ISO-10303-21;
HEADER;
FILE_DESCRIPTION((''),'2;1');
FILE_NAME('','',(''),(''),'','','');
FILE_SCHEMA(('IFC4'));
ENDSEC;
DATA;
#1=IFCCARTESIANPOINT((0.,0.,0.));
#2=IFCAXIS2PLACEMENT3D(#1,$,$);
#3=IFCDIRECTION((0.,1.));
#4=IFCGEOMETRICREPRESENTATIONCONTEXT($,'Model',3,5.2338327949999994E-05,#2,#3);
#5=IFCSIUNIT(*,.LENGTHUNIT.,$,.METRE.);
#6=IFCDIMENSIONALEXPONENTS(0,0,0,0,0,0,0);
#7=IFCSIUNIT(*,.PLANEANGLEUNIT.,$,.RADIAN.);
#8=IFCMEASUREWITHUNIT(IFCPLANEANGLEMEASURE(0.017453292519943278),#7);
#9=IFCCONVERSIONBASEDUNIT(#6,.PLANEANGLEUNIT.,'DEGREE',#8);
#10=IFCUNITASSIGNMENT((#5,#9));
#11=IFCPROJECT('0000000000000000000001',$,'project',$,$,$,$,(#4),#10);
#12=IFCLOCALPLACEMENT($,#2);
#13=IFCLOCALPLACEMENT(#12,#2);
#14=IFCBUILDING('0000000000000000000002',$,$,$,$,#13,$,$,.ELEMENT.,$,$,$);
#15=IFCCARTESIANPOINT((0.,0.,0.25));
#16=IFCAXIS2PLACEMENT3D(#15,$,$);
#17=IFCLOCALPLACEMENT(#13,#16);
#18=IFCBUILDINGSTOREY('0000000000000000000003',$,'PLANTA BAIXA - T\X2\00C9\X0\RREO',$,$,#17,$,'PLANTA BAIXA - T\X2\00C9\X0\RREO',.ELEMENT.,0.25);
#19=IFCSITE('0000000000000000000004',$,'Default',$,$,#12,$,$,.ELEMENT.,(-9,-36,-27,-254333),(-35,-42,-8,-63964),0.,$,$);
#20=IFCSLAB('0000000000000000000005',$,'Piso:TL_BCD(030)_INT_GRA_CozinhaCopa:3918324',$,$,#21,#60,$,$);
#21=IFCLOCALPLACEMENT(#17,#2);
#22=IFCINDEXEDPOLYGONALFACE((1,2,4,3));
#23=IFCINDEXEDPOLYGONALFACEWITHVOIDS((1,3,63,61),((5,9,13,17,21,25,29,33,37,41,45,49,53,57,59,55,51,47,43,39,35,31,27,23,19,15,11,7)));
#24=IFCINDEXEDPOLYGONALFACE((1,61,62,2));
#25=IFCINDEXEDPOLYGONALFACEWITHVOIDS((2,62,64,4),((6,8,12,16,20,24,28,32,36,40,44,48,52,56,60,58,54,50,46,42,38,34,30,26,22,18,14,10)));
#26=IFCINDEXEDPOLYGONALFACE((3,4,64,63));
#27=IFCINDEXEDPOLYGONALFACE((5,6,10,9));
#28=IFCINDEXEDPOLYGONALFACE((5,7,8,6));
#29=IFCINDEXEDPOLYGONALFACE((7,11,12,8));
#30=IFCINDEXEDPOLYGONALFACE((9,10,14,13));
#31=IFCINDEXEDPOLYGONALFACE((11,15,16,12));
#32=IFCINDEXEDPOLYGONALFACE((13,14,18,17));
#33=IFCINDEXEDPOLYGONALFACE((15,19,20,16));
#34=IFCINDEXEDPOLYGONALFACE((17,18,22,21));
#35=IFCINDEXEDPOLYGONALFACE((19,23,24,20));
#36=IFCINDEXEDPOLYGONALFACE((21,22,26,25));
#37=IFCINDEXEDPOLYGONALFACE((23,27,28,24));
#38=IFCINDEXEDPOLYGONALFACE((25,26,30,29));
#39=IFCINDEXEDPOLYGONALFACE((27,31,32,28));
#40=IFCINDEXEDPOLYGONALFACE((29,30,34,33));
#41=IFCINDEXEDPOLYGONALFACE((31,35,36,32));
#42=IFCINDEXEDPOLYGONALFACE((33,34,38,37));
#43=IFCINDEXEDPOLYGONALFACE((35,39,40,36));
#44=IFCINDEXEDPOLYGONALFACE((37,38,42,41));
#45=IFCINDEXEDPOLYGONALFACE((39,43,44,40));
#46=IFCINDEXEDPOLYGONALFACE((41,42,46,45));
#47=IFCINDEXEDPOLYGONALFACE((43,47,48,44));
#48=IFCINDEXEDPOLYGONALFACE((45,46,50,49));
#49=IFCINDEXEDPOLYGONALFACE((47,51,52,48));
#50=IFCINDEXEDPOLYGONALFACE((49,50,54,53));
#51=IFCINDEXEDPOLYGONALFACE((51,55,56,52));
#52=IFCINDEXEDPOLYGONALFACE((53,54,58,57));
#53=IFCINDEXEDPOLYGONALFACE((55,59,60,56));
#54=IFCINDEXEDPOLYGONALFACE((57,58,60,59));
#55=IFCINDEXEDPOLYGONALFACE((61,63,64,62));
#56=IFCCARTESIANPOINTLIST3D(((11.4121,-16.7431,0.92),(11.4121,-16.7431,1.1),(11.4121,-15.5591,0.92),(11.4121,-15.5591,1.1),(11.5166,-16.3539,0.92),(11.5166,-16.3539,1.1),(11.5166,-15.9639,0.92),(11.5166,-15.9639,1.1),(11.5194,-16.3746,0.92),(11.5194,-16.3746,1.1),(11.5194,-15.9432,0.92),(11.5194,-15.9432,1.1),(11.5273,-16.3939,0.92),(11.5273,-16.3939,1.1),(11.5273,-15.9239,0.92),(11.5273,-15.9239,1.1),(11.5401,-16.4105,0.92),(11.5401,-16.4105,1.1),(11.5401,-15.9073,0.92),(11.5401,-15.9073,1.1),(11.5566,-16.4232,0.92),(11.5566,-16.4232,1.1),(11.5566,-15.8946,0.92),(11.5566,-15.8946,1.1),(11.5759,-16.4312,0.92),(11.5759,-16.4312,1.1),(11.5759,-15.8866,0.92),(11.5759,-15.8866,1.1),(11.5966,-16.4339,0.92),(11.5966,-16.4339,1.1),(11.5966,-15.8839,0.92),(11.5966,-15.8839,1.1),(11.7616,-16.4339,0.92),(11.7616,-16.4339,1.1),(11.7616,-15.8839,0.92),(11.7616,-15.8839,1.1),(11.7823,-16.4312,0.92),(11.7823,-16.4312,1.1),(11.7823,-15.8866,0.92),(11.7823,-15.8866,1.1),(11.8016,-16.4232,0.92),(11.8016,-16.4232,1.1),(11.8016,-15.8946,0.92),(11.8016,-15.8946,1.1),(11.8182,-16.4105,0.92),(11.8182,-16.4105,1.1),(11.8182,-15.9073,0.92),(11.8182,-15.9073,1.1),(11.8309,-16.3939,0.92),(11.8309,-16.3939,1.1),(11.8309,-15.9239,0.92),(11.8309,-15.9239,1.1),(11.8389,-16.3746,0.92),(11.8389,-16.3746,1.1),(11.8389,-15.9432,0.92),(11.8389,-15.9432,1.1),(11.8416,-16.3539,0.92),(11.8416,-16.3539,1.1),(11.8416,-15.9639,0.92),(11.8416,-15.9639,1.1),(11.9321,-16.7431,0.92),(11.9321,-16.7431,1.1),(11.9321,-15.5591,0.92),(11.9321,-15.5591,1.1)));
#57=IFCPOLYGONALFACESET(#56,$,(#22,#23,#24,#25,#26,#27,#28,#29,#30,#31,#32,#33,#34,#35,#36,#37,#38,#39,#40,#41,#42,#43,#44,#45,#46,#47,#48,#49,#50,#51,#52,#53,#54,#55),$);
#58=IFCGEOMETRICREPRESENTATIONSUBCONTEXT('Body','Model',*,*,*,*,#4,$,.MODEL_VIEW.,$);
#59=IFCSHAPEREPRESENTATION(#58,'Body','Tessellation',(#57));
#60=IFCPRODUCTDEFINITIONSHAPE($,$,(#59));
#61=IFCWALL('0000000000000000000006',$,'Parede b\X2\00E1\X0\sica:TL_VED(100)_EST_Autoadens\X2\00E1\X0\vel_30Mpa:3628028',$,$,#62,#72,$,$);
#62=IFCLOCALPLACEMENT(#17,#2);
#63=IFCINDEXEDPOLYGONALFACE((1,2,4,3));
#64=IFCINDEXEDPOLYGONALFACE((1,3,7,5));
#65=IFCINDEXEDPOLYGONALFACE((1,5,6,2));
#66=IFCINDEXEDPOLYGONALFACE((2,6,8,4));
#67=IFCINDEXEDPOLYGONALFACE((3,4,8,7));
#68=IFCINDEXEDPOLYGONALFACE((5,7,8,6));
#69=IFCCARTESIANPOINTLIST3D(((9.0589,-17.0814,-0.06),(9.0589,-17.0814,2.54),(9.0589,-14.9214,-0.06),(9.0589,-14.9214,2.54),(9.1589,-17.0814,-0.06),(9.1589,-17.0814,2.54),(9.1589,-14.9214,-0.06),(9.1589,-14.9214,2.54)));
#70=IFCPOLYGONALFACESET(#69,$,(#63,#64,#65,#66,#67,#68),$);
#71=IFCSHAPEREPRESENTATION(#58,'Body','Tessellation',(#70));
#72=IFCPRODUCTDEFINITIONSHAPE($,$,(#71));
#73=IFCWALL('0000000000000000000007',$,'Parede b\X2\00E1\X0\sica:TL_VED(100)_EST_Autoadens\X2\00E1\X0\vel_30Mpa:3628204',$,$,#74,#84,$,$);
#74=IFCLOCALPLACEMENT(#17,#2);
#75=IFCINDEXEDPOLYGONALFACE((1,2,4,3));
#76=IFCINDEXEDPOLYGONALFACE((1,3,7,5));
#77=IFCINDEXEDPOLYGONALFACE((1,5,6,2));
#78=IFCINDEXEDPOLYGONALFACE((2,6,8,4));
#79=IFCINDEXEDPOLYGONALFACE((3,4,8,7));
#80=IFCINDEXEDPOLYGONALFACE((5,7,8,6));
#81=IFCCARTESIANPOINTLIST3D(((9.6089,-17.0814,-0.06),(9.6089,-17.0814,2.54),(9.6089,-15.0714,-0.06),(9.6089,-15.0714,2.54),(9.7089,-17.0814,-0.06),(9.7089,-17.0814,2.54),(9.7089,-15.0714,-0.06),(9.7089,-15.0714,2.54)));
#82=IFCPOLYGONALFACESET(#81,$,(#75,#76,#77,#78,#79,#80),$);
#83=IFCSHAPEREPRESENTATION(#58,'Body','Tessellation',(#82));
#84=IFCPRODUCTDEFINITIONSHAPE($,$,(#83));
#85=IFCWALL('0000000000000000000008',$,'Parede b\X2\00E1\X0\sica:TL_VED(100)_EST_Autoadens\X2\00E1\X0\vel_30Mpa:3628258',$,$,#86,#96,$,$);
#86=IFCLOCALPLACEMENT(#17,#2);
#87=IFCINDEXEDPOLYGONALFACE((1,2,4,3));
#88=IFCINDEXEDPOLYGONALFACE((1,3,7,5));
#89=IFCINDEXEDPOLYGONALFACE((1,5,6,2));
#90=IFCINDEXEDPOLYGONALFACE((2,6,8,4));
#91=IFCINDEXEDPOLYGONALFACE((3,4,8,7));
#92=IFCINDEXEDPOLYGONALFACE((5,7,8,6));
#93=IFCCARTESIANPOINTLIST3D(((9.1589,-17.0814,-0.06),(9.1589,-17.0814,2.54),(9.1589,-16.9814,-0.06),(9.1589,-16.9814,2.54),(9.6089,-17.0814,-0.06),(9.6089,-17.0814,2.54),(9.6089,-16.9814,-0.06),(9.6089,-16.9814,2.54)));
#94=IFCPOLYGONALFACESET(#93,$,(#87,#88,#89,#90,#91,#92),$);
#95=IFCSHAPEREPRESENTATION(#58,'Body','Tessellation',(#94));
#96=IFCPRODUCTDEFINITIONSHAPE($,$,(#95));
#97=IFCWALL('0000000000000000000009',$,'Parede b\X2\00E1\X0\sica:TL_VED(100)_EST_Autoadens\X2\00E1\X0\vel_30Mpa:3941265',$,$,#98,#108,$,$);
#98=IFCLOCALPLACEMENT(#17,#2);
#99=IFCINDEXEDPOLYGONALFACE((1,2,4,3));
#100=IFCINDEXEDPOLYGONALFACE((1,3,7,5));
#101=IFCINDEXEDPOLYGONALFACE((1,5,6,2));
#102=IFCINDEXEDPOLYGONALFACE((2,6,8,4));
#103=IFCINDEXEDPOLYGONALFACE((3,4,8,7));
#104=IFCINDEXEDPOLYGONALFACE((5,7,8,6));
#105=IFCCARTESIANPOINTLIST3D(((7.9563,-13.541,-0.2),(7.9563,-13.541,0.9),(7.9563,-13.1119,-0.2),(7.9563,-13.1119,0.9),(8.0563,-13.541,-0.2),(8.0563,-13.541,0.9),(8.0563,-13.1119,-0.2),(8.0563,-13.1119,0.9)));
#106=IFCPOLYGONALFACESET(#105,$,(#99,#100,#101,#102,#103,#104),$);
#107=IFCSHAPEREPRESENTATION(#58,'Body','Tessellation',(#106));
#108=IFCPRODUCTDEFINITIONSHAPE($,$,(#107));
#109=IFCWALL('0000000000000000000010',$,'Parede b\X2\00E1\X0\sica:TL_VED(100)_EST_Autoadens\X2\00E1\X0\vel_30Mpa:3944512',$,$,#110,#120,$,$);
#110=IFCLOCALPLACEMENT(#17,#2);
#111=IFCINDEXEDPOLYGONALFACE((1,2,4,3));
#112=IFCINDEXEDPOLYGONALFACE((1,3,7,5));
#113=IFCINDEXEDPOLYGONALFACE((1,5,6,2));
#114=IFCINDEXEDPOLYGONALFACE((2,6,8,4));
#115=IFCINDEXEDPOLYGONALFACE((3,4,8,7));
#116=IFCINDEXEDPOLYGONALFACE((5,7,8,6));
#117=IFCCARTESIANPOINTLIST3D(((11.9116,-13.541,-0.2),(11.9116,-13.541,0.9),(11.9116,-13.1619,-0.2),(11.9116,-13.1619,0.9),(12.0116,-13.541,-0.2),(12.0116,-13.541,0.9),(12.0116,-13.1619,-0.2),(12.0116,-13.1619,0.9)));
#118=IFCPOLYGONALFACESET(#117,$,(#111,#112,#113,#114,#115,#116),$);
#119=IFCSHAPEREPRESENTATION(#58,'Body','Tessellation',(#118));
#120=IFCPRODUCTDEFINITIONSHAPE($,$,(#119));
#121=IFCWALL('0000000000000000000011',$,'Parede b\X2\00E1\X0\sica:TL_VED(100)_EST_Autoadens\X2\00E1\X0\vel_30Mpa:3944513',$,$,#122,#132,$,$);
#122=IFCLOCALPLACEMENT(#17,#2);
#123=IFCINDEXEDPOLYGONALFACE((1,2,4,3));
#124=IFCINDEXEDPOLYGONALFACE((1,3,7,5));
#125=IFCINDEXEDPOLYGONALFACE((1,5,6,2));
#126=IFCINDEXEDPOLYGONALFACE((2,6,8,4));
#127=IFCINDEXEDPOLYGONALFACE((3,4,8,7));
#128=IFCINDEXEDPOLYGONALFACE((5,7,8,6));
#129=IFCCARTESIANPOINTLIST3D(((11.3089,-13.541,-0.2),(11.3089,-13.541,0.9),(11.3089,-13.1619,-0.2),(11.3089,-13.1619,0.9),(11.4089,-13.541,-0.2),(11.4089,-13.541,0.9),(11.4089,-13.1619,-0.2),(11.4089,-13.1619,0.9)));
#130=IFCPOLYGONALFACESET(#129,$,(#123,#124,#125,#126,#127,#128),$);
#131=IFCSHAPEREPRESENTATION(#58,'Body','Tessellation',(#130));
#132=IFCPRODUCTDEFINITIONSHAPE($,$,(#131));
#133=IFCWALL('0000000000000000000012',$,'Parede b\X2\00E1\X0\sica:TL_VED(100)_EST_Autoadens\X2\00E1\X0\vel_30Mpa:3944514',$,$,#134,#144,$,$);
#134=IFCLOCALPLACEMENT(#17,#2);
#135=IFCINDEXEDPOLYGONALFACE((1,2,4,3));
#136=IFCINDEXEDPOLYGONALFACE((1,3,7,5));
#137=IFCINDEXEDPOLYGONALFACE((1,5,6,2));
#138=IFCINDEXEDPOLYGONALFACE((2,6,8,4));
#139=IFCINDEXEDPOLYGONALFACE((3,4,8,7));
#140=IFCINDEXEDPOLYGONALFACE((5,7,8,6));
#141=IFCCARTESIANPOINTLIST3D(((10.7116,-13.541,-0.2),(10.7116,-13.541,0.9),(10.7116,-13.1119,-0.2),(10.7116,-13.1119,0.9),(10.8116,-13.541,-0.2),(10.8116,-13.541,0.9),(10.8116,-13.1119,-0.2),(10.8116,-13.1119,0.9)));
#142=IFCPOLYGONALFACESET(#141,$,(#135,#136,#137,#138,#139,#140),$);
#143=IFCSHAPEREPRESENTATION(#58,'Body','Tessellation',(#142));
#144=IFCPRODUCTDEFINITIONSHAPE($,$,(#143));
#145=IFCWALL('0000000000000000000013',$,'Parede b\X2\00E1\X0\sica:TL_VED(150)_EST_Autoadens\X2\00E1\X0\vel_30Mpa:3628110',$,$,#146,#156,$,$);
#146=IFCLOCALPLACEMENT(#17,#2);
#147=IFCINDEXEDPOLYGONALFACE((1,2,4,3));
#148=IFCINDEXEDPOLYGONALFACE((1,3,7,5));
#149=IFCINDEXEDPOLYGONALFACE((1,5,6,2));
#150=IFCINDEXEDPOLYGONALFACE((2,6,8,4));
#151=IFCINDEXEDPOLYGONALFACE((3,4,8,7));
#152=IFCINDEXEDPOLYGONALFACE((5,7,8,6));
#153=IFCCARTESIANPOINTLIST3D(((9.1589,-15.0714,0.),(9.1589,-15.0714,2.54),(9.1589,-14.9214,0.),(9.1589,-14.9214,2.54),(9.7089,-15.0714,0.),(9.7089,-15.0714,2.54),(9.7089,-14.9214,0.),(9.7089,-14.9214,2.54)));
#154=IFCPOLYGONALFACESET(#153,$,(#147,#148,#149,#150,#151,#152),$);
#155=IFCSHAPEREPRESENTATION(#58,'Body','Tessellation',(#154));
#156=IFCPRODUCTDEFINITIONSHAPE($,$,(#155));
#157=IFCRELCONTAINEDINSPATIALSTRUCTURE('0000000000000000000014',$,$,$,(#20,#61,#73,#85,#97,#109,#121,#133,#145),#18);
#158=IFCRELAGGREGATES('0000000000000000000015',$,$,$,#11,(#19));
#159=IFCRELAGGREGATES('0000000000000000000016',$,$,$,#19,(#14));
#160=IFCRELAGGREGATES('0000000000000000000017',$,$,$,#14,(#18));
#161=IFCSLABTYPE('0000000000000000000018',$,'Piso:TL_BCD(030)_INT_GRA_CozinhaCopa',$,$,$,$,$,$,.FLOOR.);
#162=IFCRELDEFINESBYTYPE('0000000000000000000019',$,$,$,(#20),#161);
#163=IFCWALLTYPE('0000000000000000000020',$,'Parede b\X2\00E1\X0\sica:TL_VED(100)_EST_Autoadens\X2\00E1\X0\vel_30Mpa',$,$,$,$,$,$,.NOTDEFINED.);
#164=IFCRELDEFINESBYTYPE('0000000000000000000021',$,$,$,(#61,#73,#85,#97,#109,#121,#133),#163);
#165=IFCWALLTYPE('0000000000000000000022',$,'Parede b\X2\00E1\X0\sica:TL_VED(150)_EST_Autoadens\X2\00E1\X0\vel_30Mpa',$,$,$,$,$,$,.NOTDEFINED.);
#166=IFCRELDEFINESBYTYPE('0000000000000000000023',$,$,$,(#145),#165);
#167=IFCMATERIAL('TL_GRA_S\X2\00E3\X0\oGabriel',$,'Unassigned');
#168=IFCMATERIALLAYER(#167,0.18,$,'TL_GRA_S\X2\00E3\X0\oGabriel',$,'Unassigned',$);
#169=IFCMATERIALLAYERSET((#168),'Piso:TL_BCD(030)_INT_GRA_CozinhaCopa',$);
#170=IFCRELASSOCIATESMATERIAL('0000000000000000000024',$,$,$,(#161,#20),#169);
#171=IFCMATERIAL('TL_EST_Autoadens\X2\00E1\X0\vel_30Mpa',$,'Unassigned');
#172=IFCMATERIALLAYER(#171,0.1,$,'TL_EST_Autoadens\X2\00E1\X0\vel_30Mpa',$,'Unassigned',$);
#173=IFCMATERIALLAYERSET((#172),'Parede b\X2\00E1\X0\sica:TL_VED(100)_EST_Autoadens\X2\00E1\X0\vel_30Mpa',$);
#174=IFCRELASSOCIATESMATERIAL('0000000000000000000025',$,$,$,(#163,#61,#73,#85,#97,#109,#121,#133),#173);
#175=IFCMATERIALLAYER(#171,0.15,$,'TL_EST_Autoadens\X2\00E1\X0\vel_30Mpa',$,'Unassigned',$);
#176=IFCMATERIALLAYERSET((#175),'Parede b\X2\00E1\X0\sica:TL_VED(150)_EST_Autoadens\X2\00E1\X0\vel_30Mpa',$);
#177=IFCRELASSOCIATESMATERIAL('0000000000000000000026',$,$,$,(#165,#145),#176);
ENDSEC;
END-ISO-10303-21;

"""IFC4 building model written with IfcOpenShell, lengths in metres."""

from ifc_helpers import new_model, entity, si_unit, converted_unit, direction, frame, frame_2d, origin, place, context, subcontext, project, spatial, polyline, circle_curve, parameter, trimmed, segment, composite_curve, rectangle, outline, extrude, clip, bounded_halfspace, material, layer, layer_set, layer_usage, type_object, element, save


model = new_model("IFC4")

# Units and contexts
model_context = context("Model", 3, precision=5.2338327949999994e-05, world=origin(), true_north=direction((0.0, 1.0)))
body_context = subcontext(model_context, "Body", "Model", "MODEL_VIEW")
ifc_project = project(units=[si_unit("LENGTHUNIT", "METRE"), converted_unit("PLANEANGLEUNIT", "DEGREE", entity("IfcPlaneAngleMeasure", 0.017453292519943278), si_unit("PLANEANGLEUNIT", "RADIAN"), dimensions=[0, 0, 0, 0, 0, 0, 0])], contexts=[model_context])

# Site, building, storey
site_placement = place(None, frame((0.0, 0.0, 0.0)))
site = spatial("IfcSite", under=ifc_project, at=site_placement, Name="Default", CompositionType="ELEMENT", RefLatitude=(-9, -36, -27, -254333), RefLongitude=(-35, -42, -8, -63964), RefElevation=0.0)
building_placement = place(site_placement, origin())
building = spatial("IfcBuilding", under=site, at=building_placement, CompositionType="ELEMENT")
storey_placement = place(building_placement, frame((0.0, 0.0, 0.25)))
storey = spatial("IfcBuildingStorey", under=building, at=storey_placement, Name="PLANTA BAIXA - TÉRREO", LongName="PLANTA BAIXA - TÉRREO", CompositionType="ELEMENT", Elevation=0.25)

# Slab, opening
ifc_material_1 = material(Name="TL_GRA_SãoGabriel", Category="Unassigned")
ifc_layer_1 = layer(ifc_material_1, 0.18, Name="TL_GRA_SãoGabriel", Category="Unassigned")
ifc_layer_set_1 = layer_set([ifc_layer_1], Name="Piso:TL_BCD(030)_INT_GRA_CozinhaCopa")
ifc_layer_usage_1 = layer_usage(ifc_layer_set_1, "AXIS3", "POSITIVE", 0.0)
slab_type_1 = type_object("IfcSlabType", Name="Piso:TL_BCD(030)_INT_GRA_CozinhaCopa", PredefinedType="FLOOR", material=ifc_layer_set_1)
slab_1_placement = place(storey_placement, frame((11.4121, -16.7431, 0.92)))
slab_1 = element("IfcSlab", 1, at=slab_1_placement, inside=storey, type_object=slab_type_1, material=ifc_layer_usage_1, Name="Piso:TL_BCD(030)_INT_GRA_CozinhaCopa:3918324", context=body_context, shape_type="SweptSolid", body=[
    extrude(rectangle(XDim=0.52, YDim=1.184, at=frame_2d((0.0, 0.0), x_axis=(-1.0, 0.0))), frame((0.26, 0.592, 0.18), z_axis=(0.0, 0.0, -1.0), x_axis=(-1.0, 0.0, 0.0)), (0.0, 0.0, 1.0), 0.18),
])
opening_1_placement = place(slab_1_placement, frame((-11.4121, 16.7431, 0.18)))
element("IfcOpeningElement", 2, at=opening_1_placement, cuts=slab_1, PredefinedType="OPENING", context=body_context, shape_type="SweptSolid", body=[
    extrude(outline(composite_curve([segment(trimmed(circle_curve(frame_2d((0.195, -0.0825), x_axis=(1.0, 0.0)), 0.08), [parameter(270.0)], [parameter(0.0)], True, "PARAMETER"), True, "CONTINUOUS"), segment(polyline([(0.275, -0.0825), (0.275, 0.0825)]), True, "CONTINUOUS"), segment(trimmed(circle_curve(frame_2d((0.195, 0.0825), x_axis=(1.0, 0.0)), 0.08), [parameter(0.0)], [parameter(90.0)], True, "PARAMETER"), True, "CONTINUOUS"), segment(polyline([(0.195, 0.1625), (-0.195, 0.1625)]), True, "CONTINUOUS"), segment(trimmed(circle_curve(frame_2d((-0.195, 0.0825), x_axis=(1.0, 0.0)), 0.08), [parameter(90.0)], [parameter(180.0)], True, "PARAMETER"), True, "CONTINUOUS"), segment(polyline([(-0.275, 0.0825), (-0.275, -0.0825)]), True, "CONTINUOUS"), segment(trimmed(circle_curve(frame_2d((-0.195, -0.0825), x_axis=(1.0, 0.0)), 0.08), [parameter(180.0)], [parameter(270.0)], True, "PARAMETER"), True, "CONTINUOUS"), segment(polyline([(-0.195, -0.1625), (0.195, -0.1625)]), True, "CONTINUOUS")], self_intersect=False)), frame((11.6791, -16.1589, -0.21), z_axis=(0.0, 0.0, 1.0), x_axis=(0.0, -1.0, 0.0)), (0.0, 0.0, 1.0), 0.21),
])

# Walls
ifc_material_2 = material(Name="TL_EST_Autoadensável_30Mpa", Category="Unassigned")
ifc_layer_2 = layer(ifc_material_2, 0.1, Name="TL_EST_Autoadensável_30Mpa", Category="Unassigned")
ifc_layer_set_2 = layer_set([ifc_layer_2], Name="Parede básica:TL_VED(100)_EST_Autoadensável_30Mpa")
ifc_layer_usage_2 = layer_usage(ifc_layer_set_2, "AXIS2", "NEGATIVE", 0.05)
wall_type_1 = type_object("IfcWallType", Name="Parede básica:TL_VED(100)_EST_Autoadensável_30Mpa", PredefinedType="NOTDEFINED", material=ifc_layer_set_2)
wall_1_placement = place(storey_placement, frame((9.1089, -17.0814, -0.06), z_axis=(0.0, 0.0, 1.0), x_axis=(0.0, 1.0, 0.0)))
element("IfcWall", 3, at=wall_1_placement, inside=storey, type_object=wall_type_1, material=ifc_layer_usage_2, Name="Parede básica:TL_VED(100)_EST_Autoadensável_30Mpa:3628028", context=body_context, shape_type="SweptSolid", body=[
    extrude(rectangle(XDim=2.16, YDim=0.1, at=frame_2d((1.08, 0.0), x_axis=(-1.0, 0.0))), origin(), (0.0, 0.0, 1.0), 2.6),
])
ifc_layer_usage_3 = layer_usage(ifc_layer_set_2, "AXIS2", "NEGATIVE", 0.05)
wall_2_placement = place(storey_placement, frame((9.6589, -15.0714, -0.06), z_axis=(0.0, 0.0, 1.0), x_axis=(0.0, -1.0, 0.0)))
element("IfcWall", 4, at=wall_2_placement, inside=storey, type_object=wall_type_1, material=ifc_layer_usage_3, Name="Parede básica:TL_VED(100)_EST_Autoadensável_30Mpa:3628204", context=body_context, shape_type="SweptSolid", body=[
    extrude(rectangle(XDim=2.01, YDim=0.1, at=frame_2d((1.005, 0.0), x_axis=(-1.0, 0.0))), origin(), (0.0, 0.0, 1.0), 2.6),
])
ifc_layer_usage_4 = layer_usage(ifc_layer_set_2, "AXIS2", "NEGATIVE", 0.05)
wall_3_placement = place(storey_placement, frame((9.6089, -17.0314, -0.06), z_axis=(0.0, 0.0, 1.0), x_axis=(-1.0, 0.0, 0.0)))
element("IfcWall", 5, at=wall_3_placement, inside=storey, type_object=wall_type_1, material=ifc_layer_usage_4, Name="Parede básica:TL_VED(100)_EST_Autoadensável_30Mpa:3628258", context=body_context, shape_type="SweptSolid", body=[
    extrude(rectangle(XDim=0.45, YDim=0.1, at=frame_2d((0.225, 0.0), x_axis=(-1.0, 0.0))), origin(), (0.0, 0.0, 1.0), 2.6),
])
ifc_layer_usage_5 = layer_usage(ifc_layer_set_2, "AXIS2", "NEGATIVE", 0.05)
wall_4_placement = place(storey_placement, frame((8.0063, -13.1119, -0.2), z_axis=(0.0, 0.0, 1.0), x_axis=(0.0, -1.0, 0.0)))
element("IfcWall", 6, at=wall_4_placement, inside=storey, type_object=wall_type_1, material=ifc_layer_usage_5, Name="Parede básica:TL_VED(100)_EST_Autoadensável_30Mpa:3941265", context=body_context, shape_type="Clipping", body=[
    clip(extrude(rectangle(XDim=0.4291, YDim=0.1, at=frame_2d((0.2145, 0.0), x_axis=(-1.0, 0.0))), origin(), (0.0, 0.0, 1.0), 1.1), bounded_halfspace(frame((0.0, -0.05, 1.1), z_axis=(0.0, 0.0, -1.0), x_axis=(1.0, 0.0, 0.0)), True, frame((0.0, -0.05, 1.1)), polyline([(0.0, 0.0), (0.05, 0.0), (0.4291, 0.0), (0.4291, 0.1), (0.0, 0.1), (0.0, 0.0)]))),
])
ifc_layer_usage_6 = layer_usage(ifc_layer_set_2, "AXIS2", "POSITIVE", -0.05)
wall_5_placement = place(storey_placement, frame((11.9616, -13.1619, -0.2), z_axis=(0.0, 0.0, 1.0), x_axis=(0.0, -1.0, 0.0)))
element("IfcWall", 7, at=wall_5_placement, inside=storey, type_object=wall_type_1, material=ifc_layer_usage_6, Name="Parede básica:TL_VED(100)_EST_Autoadensável_30Mpa:3944512", context=body_context, shape_type="Clipping", body=[
    clip(extrude(rectangle(XDim=0.3791, YDim=0.1, at=frame_2d((0.1895, 0.0), x_axis=(-1.0, 0.0))), origin(), (0.0, 0.0, 1.0), 1.1), bounded_halfspace(frame((0.0, -0.05, 1.1), z_axis=(0.0, 0.0, -1.0), x_axis=(0.0, 1.0, 0.0)), True, frame((0.0, -0.05, 1.1)), polyline([(0.0, 0.0), (0.3791, 0.0), (0.3791, 0.1), (0.0, 0.1), (0.0, 0.0)]))),
])
ifc_layer_usage_7 = layer_usage(ifc_layer_set_2, "AXIS2", "POSITIVE", -0.05)
wall_6_placement = place(storey_placement, frame((11.3589, -13.1619, -0.2), z_axis=(0.0, 0.0, 1.0), x_axis=(0.0, -1.0, 0.0)))
element("IfcWall", 8, at=wall_6_placement, inside=storey, type_object=wall_type_1, material=ifc_layer_usage_7, Name="Parede básica:TL_VED(100)_EST_Autoadensável_30Mpa:3944513", context=body_context, shape_type="Clipping", body=[
    clip(extrude(rectangle(XDim=0.3791, YDim=0.1, at=frame_2d((0.1895, 0.0), x_axis=(-1.0, 0.0))), origin(), (0.0, 0.0, 1.0), 1.1), bounded_halfspace(frame((0.0, -0.05, 1.1), z_axis=(0.0, 0.0, -1.0), x_axis=(0.0, 1.0, 0.0)), True, frame((0.0, -0.05, 1.1)), polyline([(0.0, 0.0), (0.3791, 0.0), (0.3791, 0.1), (0.0, 0.1), (0.0, 0.0)]))),
])
ifc_layer_usage_8 = layer_usage(ifc_layer_set_2, "AXIS2", "POSITIVE", -0.05)
wall_7_placement = place(storey_placement, frame((10.7616, -13.1119, -0.2), z_axis=(0.0, 0.0, 1.0), x_axis=(0.0, -1.0, 0.0)))
element("IfcWall", 9, at=wall_7_placement, inside=storey, type_object=wall_type_1, material=ifc_layer_usage_8, Name="Parede básica:TL_VED(100)_EST_Autoadensável_30Mpa:3944514", context=body_context, shape_type="Clipping", body=[
    clip(extrude(rectangle(XDim=0.4291, YDim=0.1, at=frame_2d((0.2145, 0.0), x_axis=(-1.0, 0.0))), origin(), (0.0, 0.0, 1.0), 1.1), bounded_halfspace(frame((0.0, -0.05, 1.1), z_axis=(0.0, 0.0, -1.0), x_axis=(0.0, 1.0, 0.0)), True, frame((0.0, -0.05, 1.1)), polyline([(0.0, 0.0), (0.4291, 0.0), (0.4291, 0.1), (0.05, 0.1), (0.0, 0.1), (0.0, 0.0)]))),
])
ifc_layer_3 = layer(ifc_material_2, 0.15, Name="TL_EST_Autoadensável_30Mpa", Category="Unassigned")
ifc_layer_set_3 = layer_set([ifc_layer_3], Name="Parede básica:TL_VED(150)_EST_Autoadensável_30Mpa")
ifc_layer_usage_9 = layer_usage(ifc_layer_set_3, "AXIS2", "NEGATIVE", 0.075)
wall_type_2 = type_object("IfcWallType", Name="Parede básica:TL_VED(150)_EST_Autoadensável_30Mpa", PredefinedType="NOTDEFINED", material=ifc_layer_set_3)
wall_8_placement = place(storey_placement, frame((9.1589, -14.9964, 0.0)))
element("IfcWall", 10, at=wall_8_placement, inside=storey, type_object=wall_type_2, material=ifc_layer_usage_9, Name="Parede básica:TL_VED(150)_EST_Autoadensável_30Mpa:3628110", context=body_context, shape_type="SweptSolid", body=[
    extrude(rectangle(XDim=0.55, YDim=0.15, at=frame_2d((0.275, 0.0), x_axis=(-1.0, 0.0))), origin(), (0.0, 0.0, 1.0), 2.54),
])

save(model, "model.ifc")
